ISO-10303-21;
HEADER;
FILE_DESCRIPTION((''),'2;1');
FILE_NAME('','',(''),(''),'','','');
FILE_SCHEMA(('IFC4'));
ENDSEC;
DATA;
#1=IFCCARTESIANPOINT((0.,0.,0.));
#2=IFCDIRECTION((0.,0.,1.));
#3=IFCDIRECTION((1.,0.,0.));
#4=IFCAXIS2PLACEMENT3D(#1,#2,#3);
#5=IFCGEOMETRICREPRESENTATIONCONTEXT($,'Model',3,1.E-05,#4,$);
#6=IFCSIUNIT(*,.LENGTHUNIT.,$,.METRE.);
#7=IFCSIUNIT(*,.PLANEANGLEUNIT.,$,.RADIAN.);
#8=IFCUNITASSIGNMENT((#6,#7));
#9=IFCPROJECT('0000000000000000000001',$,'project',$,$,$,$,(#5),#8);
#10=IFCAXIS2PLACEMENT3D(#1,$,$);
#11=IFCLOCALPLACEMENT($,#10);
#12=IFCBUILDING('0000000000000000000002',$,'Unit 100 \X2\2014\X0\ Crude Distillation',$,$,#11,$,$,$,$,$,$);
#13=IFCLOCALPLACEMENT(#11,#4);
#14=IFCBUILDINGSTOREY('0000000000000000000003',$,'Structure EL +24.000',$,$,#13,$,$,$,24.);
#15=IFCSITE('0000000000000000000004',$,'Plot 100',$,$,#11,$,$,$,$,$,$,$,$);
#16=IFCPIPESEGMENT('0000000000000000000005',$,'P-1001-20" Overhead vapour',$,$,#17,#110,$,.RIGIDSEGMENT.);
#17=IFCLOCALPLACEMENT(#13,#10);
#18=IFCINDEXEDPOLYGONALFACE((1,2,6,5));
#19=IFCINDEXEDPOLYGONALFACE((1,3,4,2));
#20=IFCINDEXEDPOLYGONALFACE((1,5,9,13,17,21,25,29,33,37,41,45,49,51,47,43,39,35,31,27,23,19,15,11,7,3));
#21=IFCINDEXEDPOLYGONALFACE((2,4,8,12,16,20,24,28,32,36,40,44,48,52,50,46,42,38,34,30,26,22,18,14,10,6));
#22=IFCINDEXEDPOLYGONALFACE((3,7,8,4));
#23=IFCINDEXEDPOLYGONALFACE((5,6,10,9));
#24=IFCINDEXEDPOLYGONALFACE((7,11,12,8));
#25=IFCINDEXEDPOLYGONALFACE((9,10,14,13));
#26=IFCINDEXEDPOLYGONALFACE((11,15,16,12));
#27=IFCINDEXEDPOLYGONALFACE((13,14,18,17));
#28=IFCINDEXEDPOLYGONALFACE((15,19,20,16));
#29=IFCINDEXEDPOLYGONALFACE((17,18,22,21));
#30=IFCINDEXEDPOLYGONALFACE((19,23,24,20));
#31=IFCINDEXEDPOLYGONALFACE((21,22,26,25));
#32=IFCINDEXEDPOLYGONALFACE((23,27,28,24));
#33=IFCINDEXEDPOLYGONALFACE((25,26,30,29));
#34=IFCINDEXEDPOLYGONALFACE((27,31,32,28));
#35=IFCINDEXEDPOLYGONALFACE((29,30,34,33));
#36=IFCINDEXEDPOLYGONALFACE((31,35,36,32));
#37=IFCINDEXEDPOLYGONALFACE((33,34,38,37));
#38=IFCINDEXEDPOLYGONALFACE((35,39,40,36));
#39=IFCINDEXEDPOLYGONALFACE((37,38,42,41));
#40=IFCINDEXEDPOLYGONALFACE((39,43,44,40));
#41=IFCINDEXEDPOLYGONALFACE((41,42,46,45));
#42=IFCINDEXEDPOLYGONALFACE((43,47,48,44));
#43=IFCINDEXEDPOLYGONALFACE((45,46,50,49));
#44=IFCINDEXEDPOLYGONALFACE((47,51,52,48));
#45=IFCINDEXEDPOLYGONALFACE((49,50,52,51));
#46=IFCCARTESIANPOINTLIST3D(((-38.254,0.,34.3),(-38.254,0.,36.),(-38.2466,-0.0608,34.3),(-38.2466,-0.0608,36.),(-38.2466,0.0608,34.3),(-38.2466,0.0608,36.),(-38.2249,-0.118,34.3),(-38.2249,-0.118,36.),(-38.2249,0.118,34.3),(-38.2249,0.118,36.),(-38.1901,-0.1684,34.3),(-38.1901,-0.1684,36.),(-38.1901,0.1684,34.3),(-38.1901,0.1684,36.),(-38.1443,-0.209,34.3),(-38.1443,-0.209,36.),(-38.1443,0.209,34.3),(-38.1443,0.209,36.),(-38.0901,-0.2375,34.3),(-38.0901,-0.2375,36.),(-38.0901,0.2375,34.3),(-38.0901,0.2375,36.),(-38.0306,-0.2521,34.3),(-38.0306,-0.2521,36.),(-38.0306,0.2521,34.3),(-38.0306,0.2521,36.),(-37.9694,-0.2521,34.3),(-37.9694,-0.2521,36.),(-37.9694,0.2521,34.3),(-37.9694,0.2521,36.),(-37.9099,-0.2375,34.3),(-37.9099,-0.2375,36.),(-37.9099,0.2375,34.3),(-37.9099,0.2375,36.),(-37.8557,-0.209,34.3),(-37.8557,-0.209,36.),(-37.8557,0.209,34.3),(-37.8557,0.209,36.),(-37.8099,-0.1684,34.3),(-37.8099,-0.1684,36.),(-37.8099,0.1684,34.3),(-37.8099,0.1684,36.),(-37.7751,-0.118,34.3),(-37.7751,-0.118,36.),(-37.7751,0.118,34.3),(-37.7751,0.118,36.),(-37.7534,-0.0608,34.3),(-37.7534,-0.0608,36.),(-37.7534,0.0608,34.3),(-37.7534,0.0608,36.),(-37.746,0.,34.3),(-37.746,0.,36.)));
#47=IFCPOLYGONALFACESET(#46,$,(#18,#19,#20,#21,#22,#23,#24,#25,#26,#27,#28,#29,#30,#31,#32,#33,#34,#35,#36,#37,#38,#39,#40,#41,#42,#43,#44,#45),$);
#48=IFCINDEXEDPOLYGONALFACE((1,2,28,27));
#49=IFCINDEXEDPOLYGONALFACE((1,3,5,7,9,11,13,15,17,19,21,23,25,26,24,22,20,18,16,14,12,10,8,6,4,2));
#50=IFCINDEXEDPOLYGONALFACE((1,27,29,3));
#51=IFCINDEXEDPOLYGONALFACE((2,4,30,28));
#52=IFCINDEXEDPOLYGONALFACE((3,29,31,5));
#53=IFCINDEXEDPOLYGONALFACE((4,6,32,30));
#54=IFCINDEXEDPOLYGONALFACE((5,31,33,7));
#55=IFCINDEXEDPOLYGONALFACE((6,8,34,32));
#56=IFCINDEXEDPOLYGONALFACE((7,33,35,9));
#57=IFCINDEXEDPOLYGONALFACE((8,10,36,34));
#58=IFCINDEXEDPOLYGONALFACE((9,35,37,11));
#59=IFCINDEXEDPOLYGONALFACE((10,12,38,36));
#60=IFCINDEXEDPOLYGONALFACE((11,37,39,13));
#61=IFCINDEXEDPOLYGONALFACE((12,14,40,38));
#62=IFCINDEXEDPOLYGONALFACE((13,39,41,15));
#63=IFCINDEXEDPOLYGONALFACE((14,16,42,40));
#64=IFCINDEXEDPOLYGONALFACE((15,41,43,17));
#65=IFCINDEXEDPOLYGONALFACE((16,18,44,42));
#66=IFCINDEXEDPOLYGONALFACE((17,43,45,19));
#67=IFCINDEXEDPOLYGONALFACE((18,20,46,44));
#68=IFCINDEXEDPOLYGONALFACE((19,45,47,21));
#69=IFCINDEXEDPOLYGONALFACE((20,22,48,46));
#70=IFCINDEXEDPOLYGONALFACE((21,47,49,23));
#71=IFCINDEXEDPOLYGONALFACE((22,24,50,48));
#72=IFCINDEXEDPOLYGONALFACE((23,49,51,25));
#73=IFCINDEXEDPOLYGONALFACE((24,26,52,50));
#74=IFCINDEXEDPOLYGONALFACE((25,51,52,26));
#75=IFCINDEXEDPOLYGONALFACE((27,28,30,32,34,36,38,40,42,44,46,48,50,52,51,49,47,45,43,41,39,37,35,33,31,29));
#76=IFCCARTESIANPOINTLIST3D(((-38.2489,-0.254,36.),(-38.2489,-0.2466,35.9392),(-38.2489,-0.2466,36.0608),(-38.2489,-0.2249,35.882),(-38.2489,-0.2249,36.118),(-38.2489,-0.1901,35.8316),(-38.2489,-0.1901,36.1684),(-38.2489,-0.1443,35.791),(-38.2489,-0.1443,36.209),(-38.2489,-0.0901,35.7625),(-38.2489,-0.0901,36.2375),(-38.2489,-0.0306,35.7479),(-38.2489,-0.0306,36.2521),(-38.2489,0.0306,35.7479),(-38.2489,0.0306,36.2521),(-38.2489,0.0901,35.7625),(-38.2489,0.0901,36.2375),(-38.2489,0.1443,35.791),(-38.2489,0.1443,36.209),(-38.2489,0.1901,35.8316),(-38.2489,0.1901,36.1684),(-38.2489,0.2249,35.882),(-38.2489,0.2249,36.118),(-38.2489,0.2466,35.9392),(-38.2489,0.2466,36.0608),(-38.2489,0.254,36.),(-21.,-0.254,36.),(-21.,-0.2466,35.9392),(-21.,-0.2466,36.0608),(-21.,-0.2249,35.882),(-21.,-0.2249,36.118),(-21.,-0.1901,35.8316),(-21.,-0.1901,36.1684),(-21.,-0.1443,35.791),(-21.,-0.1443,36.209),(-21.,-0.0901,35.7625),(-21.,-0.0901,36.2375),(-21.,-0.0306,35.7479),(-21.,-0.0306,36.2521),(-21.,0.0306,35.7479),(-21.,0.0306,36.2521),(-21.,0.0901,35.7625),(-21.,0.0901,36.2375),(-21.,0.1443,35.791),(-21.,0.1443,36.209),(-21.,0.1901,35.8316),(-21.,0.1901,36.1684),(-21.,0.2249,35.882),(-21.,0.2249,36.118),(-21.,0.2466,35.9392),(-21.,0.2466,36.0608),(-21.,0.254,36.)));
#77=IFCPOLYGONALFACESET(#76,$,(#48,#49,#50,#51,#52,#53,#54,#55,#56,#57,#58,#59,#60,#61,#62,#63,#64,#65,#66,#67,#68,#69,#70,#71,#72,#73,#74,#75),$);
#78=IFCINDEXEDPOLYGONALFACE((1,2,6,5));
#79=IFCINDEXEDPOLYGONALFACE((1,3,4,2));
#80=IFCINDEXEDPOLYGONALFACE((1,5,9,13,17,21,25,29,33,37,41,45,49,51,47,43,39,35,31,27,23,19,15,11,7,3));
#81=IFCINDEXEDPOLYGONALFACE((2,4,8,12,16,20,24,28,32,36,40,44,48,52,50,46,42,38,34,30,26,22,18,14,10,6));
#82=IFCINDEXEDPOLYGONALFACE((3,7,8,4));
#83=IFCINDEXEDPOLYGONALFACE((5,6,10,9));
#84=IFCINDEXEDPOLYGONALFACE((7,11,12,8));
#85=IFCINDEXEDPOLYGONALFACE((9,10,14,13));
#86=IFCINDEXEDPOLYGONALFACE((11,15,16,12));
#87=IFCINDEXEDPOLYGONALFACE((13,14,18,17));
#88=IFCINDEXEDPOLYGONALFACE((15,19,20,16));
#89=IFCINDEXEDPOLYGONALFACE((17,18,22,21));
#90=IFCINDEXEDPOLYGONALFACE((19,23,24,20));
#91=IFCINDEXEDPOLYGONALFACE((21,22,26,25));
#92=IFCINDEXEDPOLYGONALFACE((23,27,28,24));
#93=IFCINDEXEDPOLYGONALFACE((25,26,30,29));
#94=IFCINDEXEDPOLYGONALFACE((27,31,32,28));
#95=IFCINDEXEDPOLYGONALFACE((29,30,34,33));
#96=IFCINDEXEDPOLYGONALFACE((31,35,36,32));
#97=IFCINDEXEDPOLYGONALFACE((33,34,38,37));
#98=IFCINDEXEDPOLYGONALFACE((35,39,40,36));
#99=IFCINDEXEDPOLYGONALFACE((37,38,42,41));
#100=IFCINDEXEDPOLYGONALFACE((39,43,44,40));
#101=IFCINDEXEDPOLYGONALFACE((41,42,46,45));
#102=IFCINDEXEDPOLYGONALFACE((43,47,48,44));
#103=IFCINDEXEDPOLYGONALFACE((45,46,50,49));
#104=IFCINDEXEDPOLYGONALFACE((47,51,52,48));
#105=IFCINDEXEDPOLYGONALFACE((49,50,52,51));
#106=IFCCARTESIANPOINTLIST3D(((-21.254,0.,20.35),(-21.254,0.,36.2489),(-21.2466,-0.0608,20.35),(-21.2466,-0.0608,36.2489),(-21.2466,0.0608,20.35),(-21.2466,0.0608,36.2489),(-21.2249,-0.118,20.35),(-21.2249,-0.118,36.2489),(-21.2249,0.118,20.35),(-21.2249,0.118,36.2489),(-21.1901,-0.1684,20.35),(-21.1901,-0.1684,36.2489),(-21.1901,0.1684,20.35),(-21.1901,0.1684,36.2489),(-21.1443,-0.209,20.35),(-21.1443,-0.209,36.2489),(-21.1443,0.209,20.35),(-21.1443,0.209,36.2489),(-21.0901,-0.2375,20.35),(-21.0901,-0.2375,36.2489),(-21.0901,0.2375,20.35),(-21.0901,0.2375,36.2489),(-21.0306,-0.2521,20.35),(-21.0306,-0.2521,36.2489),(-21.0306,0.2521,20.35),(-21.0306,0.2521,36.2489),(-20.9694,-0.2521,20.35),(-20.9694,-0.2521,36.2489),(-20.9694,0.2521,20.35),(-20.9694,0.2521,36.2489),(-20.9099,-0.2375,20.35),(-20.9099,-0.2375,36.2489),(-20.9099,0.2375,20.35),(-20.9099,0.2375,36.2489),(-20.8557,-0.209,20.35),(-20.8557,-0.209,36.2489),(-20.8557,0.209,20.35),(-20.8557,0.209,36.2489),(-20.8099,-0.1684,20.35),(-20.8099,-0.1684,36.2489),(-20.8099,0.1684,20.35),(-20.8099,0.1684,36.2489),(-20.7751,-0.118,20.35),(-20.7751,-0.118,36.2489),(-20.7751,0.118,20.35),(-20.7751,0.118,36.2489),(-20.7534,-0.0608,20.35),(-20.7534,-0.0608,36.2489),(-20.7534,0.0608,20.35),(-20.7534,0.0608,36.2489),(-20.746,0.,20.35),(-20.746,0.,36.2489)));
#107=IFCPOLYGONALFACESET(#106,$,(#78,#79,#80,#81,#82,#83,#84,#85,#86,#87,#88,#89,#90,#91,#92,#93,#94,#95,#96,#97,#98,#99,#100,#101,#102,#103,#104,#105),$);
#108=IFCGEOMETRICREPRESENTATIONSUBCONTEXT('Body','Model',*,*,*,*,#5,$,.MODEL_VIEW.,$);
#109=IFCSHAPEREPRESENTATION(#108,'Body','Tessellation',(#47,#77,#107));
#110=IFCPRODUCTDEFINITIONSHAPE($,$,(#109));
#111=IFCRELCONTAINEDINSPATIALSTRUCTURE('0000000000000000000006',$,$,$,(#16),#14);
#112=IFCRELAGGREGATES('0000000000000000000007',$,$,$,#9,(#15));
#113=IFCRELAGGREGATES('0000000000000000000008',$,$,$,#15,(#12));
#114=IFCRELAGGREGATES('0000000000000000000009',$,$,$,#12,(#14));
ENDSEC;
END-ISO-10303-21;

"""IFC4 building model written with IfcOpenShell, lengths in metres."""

from ifc_helpers import new_model, si_unit, frame, origin, origin_with_axes, origin_2d, place, context, subcontext, project, spatial, circle, extrude, element, save


model = new_model("IFC4")

# Units and contexts
model_context = context("Model", 3, precision=1e-05, world=origin_with_axes())
body_context = subcontext(model_context, "Body", "Model", "MODEL_VIEW")
ifc_project = project(units=[si_unit("LENGTHUNIT", "METRE"), si_unit("PLANEANGLEUNIT", "RADIAN")], contexts=[model_context])

# Site, building, storey
placement = place(None, origin())
site = spatial("IfcSite", under=ifc_project, at=placement, Name="Plot 100")
building = spatial("IfcBuilding", under=site, at=placement, Name="Unit 100 — Crude Distillation")
storey_placement = place(placement, origin_with_axes())
storey = spatial("IfcBuildingStorey", under=building, at=storey_placement, Name="Structure EL +24.000", Elevation=24.0)

# Pipe segment
pipe_segment_placement = place(storey_placement, origin_with_axes())
element("IfcPipeSegment", 1, at=pipe_segment_placement, inside=storey, Name="P-1001-20\" Overhead vapour", PredefinedType="RIGIDSEGMENT", context=body_context, shape_type="SweptSolid", body=[
    extrude(circle(Radius=0.254, at=origin_2d()), frame((-38.0, 0.0, 34.3), z_axis=(0.0, 0.0, 1.0), x_axis=(1.0, 0.0, 0.0)), (0.0, 0.0, 1.0), 1.7),
    extrude(circle(Radius=0.254, at=origin_2d()), frame((-38.2489, 0.0, 36.0), z_axis=(1.0, 0.0, 0.0), x_axis=(0.0, 1.0, 0.0)), (0.0, 0.0, 1.0), 17.2489),
    extrude(circle(Radius=0.254, at=origin_2d()), frame((-21.0, 0.0, 36.2489), z_axis=(0.0, 0.0, -1.0), x_axis=(1.0, 0.0, 0.0)), (0.0, 0.0, 1.0), 15.8989),
])

save(model, "model.ifc")
